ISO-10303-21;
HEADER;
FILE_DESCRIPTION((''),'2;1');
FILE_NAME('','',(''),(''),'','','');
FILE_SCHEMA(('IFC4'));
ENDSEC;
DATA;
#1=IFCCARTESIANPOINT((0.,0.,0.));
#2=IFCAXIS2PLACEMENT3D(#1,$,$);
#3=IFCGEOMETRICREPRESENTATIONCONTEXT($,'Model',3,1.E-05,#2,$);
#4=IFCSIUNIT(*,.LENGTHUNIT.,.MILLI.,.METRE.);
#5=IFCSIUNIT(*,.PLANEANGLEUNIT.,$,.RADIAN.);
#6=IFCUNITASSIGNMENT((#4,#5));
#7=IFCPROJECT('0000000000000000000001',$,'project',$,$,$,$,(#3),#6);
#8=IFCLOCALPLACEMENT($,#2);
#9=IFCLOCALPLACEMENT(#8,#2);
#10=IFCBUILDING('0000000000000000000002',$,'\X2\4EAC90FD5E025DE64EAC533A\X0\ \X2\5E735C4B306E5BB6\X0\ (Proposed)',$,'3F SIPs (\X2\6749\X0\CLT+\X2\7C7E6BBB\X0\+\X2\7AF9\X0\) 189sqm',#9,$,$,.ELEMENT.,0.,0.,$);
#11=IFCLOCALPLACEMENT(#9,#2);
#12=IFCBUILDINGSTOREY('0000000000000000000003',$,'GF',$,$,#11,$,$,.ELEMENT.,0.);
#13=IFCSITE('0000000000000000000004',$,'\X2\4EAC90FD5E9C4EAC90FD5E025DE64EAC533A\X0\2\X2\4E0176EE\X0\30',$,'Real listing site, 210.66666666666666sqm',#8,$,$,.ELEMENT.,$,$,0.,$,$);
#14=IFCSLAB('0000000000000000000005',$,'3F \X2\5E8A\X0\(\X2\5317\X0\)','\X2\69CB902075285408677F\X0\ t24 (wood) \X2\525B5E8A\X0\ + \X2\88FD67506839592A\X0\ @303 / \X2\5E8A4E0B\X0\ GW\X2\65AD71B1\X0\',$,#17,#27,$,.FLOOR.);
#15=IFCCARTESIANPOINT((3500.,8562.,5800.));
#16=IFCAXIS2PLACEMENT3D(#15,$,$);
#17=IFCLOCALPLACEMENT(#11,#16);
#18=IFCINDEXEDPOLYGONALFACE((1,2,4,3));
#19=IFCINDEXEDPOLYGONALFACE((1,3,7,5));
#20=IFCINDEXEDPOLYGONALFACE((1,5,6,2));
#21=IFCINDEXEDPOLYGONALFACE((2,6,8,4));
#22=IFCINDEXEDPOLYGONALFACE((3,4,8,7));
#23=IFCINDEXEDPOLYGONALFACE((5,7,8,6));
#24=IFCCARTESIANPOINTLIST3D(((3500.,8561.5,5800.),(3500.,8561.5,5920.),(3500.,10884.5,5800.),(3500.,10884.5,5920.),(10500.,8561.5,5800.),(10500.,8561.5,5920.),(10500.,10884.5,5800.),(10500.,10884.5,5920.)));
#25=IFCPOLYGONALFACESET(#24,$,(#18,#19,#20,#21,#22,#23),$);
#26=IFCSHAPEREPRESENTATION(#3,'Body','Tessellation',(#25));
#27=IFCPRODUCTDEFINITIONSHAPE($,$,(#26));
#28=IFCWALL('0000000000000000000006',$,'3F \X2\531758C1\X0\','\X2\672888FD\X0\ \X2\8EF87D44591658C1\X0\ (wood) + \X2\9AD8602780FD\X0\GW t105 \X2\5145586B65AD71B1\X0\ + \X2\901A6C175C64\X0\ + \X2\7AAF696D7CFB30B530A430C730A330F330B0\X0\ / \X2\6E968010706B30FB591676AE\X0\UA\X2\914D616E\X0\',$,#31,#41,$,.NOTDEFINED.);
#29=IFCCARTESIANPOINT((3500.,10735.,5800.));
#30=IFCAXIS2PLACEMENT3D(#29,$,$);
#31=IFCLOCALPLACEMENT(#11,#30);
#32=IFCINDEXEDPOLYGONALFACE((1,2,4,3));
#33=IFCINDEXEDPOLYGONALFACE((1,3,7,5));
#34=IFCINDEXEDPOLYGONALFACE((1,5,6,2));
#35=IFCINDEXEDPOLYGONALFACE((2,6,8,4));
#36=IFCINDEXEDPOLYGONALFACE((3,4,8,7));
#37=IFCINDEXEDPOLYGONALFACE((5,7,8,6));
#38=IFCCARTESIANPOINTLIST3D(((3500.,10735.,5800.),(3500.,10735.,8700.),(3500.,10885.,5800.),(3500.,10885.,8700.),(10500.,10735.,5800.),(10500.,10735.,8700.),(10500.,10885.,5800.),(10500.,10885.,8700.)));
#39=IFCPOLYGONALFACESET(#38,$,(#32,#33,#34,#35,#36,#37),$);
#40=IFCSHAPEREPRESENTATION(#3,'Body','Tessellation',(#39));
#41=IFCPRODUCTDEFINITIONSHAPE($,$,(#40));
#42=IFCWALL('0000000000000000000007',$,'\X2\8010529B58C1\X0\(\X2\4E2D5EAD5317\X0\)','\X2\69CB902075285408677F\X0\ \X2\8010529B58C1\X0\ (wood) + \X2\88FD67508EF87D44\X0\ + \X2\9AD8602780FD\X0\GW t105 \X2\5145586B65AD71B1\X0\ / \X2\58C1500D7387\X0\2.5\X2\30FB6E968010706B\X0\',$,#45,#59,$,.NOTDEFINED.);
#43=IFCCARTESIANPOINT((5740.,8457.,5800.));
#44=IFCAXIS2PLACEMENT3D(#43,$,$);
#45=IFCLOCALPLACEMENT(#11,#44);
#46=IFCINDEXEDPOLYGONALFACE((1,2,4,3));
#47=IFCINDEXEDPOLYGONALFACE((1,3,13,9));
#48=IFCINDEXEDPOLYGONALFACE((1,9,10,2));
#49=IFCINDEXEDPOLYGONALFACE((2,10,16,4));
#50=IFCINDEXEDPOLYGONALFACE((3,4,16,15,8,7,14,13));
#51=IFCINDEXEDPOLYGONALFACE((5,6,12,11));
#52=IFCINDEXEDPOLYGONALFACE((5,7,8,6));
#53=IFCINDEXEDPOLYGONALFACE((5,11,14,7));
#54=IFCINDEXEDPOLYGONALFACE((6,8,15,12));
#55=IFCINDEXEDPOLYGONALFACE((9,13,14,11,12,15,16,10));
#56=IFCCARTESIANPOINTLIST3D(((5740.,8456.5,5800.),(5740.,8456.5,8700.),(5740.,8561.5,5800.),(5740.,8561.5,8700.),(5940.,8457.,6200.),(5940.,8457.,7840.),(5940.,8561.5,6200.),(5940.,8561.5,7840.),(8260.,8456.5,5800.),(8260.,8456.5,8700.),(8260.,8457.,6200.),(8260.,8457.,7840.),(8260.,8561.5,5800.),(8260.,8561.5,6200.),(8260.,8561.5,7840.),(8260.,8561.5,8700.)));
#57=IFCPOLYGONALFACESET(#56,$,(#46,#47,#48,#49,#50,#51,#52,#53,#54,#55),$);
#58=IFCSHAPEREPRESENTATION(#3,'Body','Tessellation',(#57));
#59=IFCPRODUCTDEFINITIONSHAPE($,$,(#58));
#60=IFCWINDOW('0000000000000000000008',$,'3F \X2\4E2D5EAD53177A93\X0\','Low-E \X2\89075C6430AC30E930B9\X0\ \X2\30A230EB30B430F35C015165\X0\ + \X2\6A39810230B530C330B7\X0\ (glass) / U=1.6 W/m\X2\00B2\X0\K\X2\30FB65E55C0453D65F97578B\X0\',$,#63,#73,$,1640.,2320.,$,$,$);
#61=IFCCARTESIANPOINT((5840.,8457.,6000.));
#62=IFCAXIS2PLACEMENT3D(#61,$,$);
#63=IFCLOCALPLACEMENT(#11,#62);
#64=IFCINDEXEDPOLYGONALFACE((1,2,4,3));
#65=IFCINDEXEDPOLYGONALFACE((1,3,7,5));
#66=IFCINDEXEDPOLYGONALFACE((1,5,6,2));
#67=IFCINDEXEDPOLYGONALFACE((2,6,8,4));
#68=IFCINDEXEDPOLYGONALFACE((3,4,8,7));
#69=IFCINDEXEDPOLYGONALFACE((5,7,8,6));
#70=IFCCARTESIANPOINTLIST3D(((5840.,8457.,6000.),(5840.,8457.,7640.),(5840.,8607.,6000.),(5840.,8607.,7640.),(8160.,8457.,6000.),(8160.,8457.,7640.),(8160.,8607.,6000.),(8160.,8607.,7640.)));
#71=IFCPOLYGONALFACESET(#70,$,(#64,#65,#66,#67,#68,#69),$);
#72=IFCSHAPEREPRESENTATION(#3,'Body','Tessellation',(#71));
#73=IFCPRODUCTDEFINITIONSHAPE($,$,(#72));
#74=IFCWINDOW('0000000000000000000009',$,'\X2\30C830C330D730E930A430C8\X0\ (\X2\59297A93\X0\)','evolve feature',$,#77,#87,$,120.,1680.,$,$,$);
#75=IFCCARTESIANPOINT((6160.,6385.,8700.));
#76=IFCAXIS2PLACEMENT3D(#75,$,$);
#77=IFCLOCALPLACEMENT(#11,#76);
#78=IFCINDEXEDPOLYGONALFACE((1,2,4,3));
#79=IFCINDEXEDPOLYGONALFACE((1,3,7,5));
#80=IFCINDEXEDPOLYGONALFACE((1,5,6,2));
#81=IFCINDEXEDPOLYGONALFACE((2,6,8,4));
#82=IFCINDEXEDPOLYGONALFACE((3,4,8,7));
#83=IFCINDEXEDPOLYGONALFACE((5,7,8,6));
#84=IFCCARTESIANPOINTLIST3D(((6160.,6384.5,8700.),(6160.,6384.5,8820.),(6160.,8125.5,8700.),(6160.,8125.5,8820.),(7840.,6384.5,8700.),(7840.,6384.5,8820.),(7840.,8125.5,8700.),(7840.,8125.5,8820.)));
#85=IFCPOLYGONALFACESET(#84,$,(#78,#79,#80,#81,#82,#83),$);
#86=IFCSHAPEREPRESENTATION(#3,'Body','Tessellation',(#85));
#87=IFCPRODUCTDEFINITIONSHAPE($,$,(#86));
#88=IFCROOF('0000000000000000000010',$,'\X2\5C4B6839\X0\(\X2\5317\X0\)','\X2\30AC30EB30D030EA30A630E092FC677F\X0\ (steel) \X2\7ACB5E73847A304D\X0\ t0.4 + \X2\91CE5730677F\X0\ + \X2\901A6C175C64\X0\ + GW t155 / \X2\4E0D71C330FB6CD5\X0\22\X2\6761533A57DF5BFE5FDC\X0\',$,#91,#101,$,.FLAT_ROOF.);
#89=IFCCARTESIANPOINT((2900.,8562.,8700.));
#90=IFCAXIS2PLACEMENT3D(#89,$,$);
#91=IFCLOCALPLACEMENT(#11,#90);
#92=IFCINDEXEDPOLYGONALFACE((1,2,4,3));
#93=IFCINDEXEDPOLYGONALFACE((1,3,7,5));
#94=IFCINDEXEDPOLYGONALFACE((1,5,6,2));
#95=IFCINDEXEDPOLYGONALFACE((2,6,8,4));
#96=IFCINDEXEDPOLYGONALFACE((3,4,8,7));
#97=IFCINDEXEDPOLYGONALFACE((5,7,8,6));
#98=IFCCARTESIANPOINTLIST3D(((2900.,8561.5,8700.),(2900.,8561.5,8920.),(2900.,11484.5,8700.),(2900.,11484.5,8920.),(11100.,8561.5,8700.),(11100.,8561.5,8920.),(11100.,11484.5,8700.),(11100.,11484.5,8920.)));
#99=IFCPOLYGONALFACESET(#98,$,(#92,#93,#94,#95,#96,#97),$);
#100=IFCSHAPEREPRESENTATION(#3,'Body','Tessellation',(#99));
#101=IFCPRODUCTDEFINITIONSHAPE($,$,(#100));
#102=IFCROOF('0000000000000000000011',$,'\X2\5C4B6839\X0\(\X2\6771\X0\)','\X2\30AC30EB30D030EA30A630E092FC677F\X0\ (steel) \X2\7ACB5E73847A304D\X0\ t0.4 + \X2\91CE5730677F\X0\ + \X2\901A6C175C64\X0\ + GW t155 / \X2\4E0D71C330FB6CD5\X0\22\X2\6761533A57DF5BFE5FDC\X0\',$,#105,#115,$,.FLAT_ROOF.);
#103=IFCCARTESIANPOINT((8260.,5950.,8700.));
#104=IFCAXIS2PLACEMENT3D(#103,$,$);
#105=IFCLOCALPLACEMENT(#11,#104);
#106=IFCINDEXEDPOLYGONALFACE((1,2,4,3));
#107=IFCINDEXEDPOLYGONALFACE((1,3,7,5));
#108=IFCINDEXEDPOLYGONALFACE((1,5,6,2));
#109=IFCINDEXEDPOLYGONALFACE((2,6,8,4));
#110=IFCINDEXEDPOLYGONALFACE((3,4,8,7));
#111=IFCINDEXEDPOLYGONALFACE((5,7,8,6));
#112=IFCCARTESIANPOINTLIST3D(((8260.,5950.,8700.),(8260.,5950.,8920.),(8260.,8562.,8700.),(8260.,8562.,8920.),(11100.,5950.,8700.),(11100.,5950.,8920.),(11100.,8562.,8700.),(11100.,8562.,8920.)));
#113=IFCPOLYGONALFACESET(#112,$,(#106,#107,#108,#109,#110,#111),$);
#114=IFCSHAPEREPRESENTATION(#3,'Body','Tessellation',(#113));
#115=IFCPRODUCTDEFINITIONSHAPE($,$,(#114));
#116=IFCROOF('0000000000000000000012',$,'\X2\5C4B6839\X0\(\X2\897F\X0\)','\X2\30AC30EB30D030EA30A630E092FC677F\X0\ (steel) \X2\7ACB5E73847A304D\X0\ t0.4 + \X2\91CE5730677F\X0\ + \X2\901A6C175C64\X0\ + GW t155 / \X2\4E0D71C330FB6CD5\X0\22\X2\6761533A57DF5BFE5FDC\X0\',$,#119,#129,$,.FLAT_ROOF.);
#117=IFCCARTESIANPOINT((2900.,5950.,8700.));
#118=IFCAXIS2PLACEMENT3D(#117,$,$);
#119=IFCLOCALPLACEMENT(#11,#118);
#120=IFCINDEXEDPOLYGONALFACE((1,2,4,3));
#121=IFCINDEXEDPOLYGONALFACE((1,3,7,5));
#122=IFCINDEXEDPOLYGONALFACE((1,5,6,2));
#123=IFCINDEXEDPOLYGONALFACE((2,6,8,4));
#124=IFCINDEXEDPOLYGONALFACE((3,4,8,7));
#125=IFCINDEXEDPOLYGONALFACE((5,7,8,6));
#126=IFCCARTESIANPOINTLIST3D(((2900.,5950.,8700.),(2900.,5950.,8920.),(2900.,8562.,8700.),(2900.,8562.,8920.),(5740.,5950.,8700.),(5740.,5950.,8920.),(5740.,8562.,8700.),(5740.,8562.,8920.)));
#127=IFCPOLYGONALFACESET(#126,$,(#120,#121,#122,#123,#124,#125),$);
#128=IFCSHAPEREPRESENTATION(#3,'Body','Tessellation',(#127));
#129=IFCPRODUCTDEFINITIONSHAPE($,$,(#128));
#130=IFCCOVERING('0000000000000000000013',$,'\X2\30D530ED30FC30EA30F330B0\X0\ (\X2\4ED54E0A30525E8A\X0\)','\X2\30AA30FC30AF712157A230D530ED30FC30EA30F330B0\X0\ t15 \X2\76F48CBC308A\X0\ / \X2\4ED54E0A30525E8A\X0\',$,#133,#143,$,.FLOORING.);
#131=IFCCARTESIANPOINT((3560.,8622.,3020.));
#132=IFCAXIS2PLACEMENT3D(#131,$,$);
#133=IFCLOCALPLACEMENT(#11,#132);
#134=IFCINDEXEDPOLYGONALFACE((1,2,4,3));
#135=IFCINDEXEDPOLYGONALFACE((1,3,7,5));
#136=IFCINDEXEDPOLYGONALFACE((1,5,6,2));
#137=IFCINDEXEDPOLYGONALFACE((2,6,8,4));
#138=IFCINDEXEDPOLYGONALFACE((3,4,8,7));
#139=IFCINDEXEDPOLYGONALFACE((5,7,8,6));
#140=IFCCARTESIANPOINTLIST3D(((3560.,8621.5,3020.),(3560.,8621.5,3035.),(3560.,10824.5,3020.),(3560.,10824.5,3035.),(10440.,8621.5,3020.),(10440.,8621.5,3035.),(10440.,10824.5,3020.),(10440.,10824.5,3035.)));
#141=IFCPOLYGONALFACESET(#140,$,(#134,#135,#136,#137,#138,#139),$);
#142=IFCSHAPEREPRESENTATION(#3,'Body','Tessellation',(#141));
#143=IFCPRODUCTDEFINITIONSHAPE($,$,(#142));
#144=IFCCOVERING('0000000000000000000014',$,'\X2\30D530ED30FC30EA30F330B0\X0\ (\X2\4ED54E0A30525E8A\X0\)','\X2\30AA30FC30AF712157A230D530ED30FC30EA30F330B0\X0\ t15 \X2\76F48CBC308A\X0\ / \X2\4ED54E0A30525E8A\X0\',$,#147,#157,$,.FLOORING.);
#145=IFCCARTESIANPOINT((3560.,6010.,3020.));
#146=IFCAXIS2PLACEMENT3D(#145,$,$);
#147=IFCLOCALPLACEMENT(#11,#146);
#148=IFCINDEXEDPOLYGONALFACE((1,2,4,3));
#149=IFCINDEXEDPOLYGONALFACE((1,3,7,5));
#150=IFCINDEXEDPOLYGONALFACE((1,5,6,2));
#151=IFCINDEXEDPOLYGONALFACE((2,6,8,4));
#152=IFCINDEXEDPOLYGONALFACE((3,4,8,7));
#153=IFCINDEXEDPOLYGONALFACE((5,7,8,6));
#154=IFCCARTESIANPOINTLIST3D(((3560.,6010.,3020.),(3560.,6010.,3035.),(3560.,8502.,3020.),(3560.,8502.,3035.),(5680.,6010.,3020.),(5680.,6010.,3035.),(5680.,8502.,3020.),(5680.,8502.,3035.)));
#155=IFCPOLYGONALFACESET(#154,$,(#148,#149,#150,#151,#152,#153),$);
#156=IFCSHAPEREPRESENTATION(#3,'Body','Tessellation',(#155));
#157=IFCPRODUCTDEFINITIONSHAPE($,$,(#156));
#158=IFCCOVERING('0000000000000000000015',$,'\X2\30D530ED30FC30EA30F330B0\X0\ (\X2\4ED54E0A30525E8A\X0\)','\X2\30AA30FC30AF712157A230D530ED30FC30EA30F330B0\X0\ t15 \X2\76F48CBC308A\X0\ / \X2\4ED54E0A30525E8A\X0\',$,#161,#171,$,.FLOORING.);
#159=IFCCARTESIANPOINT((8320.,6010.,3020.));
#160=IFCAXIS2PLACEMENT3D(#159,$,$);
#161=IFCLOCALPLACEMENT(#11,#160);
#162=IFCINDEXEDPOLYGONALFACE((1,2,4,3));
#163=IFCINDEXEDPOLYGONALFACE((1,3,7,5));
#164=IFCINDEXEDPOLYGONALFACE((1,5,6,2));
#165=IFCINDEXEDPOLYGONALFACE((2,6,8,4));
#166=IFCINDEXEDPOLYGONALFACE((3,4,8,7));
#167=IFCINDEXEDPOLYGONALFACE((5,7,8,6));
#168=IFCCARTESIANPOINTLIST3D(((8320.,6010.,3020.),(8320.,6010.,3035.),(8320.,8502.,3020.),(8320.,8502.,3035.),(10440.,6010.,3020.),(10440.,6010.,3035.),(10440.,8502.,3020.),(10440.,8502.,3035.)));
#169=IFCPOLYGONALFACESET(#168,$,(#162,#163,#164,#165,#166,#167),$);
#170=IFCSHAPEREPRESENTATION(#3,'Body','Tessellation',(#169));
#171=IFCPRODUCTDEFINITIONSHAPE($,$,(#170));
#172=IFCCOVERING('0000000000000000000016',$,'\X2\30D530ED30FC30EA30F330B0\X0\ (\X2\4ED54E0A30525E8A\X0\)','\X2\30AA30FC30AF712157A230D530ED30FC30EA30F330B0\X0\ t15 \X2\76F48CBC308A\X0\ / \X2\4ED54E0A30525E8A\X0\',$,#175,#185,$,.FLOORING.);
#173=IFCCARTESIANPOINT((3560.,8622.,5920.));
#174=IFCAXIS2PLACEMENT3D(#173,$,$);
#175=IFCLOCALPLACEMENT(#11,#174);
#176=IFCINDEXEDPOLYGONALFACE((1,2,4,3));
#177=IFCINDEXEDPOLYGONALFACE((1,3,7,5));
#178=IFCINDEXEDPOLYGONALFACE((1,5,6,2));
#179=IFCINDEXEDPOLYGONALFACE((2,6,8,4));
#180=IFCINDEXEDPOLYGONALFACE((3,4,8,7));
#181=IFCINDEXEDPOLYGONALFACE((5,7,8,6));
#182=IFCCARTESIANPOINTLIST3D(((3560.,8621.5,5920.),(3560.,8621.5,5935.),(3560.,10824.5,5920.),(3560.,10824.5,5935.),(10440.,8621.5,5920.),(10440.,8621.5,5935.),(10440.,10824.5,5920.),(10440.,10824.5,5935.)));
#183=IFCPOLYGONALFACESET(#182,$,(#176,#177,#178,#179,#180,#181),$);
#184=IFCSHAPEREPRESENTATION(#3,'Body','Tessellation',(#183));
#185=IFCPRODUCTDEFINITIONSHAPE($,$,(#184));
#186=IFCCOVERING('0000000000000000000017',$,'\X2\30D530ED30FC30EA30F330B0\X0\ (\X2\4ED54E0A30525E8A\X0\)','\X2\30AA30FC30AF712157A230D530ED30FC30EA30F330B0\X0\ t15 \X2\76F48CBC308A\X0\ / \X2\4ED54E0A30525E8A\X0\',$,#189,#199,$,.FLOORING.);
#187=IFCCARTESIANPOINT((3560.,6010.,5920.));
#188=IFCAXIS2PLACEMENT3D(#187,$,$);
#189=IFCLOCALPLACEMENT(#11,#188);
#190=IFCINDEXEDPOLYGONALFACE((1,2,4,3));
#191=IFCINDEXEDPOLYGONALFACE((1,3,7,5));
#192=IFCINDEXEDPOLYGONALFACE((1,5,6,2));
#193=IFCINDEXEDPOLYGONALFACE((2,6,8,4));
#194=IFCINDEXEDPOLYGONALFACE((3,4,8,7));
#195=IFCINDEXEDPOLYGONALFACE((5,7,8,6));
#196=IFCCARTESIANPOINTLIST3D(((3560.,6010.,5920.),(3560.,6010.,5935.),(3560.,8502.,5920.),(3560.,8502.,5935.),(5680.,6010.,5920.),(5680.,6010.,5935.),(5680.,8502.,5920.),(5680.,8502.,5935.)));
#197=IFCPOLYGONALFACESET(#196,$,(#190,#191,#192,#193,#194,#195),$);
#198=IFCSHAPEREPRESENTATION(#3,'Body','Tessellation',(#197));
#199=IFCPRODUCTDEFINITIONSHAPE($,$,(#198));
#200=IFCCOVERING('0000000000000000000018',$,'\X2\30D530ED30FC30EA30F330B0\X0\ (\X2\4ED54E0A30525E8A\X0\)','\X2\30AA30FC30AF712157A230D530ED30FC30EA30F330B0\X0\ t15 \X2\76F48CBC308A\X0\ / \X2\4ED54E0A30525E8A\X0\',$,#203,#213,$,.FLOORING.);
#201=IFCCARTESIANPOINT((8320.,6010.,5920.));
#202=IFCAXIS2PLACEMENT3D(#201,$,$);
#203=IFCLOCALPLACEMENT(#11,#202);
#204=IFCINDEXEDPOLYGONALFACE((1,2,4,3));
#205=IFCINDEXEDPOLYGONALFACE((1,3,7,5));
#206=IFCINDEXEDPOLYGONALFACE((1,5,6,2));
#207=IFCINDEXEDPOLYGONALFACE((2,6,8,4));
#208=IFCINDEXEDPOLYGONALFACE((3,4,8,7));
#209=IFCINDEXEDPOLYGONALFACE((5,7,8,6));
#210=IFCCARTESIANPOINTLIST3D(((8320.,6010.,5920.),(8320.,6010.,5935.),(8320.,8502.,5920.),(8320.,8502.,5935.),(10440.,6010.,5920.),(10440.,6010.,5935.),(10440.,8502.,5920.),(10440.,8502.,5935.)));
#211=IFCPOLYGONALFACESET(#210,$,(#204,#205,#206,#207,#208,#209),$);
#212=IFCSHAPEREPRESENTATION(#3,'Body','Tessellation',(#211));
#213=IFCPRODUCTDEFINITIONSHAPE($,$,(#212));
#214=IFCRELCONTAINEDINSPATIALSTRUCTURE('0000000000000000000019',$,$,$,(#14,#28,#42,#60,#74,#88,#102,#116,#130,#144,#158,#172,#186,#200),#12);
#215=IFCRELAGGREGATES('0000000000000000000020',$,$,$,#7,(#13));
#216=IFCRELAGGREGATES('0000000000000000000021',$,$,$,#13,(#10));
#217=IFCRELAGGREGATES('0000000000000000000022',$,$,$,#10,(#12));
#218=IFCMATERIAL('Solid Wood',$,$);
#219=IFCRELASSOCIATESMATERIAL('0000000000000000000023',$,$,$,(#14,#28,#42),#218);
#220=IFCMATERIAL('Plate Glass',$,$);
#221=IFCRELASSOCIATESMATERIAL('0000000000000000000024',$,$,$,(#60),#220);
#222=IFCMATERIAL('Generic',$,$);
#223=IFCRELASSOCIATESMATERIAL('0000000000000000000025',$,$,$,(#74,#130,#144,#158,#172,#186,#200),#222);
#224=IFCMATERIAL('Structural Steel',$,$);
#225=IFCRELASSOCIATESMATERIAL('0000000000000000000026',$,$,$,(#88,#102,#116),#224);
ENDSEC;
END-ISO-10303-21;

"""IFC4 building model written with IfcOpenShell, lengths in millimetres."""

from ifc_helpers import new_model, si_unit, frame, frame_2d, origin, place, context, project, spatial, rectangle, extrude, material, element, fill, save


model = new_model("IFC4")

# Units and contexts
model_context = context("Model", 3, precision=1e-05, world=origin())
ifc_project = project(units=[si_unit("LENGTHUNIT", "METRE", prefix="MILLI"), si_unit("PLANEANGLEUNIT", "RADIAN")], contexts=[model_context])

# Site, building, storey
site_placement = place(None, origin())
site = spatial("IfcSite", under=ifc_project, at=site_placement, Name="京都府京都市左京区2丁目30", ObjectType="Real listing site, 210.66666666666666sqm", CompositionType="ELEMENT", RefElevation=0.0)
building_placement = place(site_placement, origin())
building = spatial("IfcBuilding", under=site, at=building_placement, Name="京都市左京区 平屋の家 (Proposed)", ObjectType="3F SIPs (杉CLT+籾殻+竹) 189sqm", CompositionType="ELEMENT", ElevationOfRefHeight=0.0, ElevationOfTerrain=0.0)
storey_placement = place(building_placement, origin())
storey = spatial("IfcBuildingStorey", under=building, at=storey_placement, Name="GF", CompositionType="ELEMENT", Elevation=0.0)

# Slab
ifc_material_1 = material(Name="Solid Wood")
slab_placement = place(storey_placement, frame((3500.0, 8562.0, 5800.0)))
element("IfcSlab", 1, at=slab_placement, inside=storey, material=ifc_material_1, Name="3F 床(北)", Description="構造用合板 t24 (wood) 剛床 + 製材根太 @303 / 床下 GW断熱", PredefinedType="FLOOR", context=model_context, shape_type="SweptSolid", body=[
    extrude(rectangle(XDim=7000.0, YDim=2323.0, at=frame_2d((3500.0, 1161.0))), frame((3500.0, 8562.0, 5800.0)), (0.0, 0.0, 1.0), 120.0),
])

# Wall
wall_1_placement = place(storey_placement, frame((3500.0, 10735.0, 5800.0)))
element("IfcWall", 2, at=wall_1_placement, inside=storey, material=ifc_material_1, Name="3F 北壁", Description="木製 軸組外壁 (wood) + 高性能GW t105 充填断熱 + 通気層 + 窯業系サイディング / 準耐火・外皮UA配慮", PredefinedType="NOTDEFINED", context=model_context, shape_type="SweptSolid", body=[
    extrude(rectangle(XDim=7000.0, YDim=150.0, at=frame_2d((3500.0, 75.0))), frame((3500.0, 10735.0, 5800.0)), (0.0, 0.0, 1.0), 2900.0),
])

# Wall, opening, window
wall_2_placement = place(storey_placement, frame((5740.0, 8457.0, 5800.0)))
wall_2 = element("IfcWall", 3, at=wall_2_placement, inside=storey, material=ifc_material_1, Name="耐力壁(中庭北)", Description="構造用合板 耐力壁 (wood) + 製材軸組 + 高性能GW t105 充填断熱 / 壁倍率2.5・準耐火", PredefinedType="NOTDEFINED", context=model_context, shape_type="SweptSolid", body=[
    extrude(rectangle(XDim=2520.0, YDim=105.0, at=frame_2d((1260.0, 52.0))), frame((5740.0, 8457.0, 5800.0)), (0.0, 0.0, 1.0), 2900.0),
])
opening_placement = place(storey_placement, frame((5840.0, 8457.0, 6000.0)))
opening = element("IfcOpeningElement", 4, at=opening_placement, cuts=wall_2, PredefinedType="NOTDEFINED", context=model_context, shape_type="SweptSolid", body=[
    extrude(rectangle(XDim=2320.0, YDim=150.0, at=frame_2d((1160.0, 75.0))), frame((5840.0, 8457.0, 6000.0)), (0.0, 0.0, 1.0), 1640.0),
])
ifc_material_2 = material(Name="Plate Glass")
window_1_placement = place(storey_placement, frame((5840.0, 8457.0, 6000.0)))
window_1 = element("IfcWindow", 5, at=window_1_placement, inside=storey, material=ifc_material_2, Name="3F 中庭北窓", Description="Low-E 複層ガラス アルゴン封入 + 樹脂サッシ (glass) / U=1.6 W/m²K・日射取得型", OverallHeight=1640.0, OverallWidth=2320.0, context=model_context, shape_type="SweptSolid", body=[
    extrude(rectangle(XDim=2320.0, YDim=150.0, at=frame_2d((1160.0, 75.0))), frame((5840.0, 8457.0, 6000.0)), (0.0, 0.0, 1.0), 1640.0),
])
fill(opening, window_1)

# Window
ifc_material_3 = material(Name="Generic")
window_2_placement = place(storey_placement, frame((6160.0, 6385.0, 8700.0)))
element("IfcWindow", 6, at=window_2_placement, inside=storey, material=ifc_material_3, Name="トップライト (天窓)", Description="evolve feature", OverallHeight=120.0, OverallWidth=1680.0, context=model_context, shape_type="SweptSolid", body=[
    extrude(rectangle(XDim=1680.0, YDim=1741.0, at=frame_2d((840.0, 870.0))), frame((6160.0, 6385.0, 8700.0)), (0.0, 0.0, 1.0), 120.0),
])

# Roofs
ifc_material_4 = material(Name="Structural Steel")
roof_1_placement = place(storey_placement, frame((2900.0, 8562.0, 8700.0)))
element("IfcRoof", 7, at=roof_1_placement, inside=storey, material=ifc_material_4, Name="屋根(北)", Description="ガルバリウム鋼板 (steel) 立平葺き t0.4 + 野地板 + 通気層 + GW t155 / 不燃・法22条区域対応", PredefinedType="FLAT_ROOF", context=model_context, shape_type="SweptSolid", body=[
    extrude(rectangle(XDim=8200.0, YDim=2923.0, at=frame_2d((4100.0, 1461.0))), frame((2900.0, 8562.0, 8700.0)), (0.0, 0.0, 1.0), 220.0),
])
roof_2_placement = place(storey_placement, frame((8260.0, 5950.0, 8700.0)))
element("IfcRoof", 8, at=roof_2_placement, inside=storey, material=ifc_material_4, Name="屋根(東)", Description="ガルバリウム鋼板 (steel) 立平葺き t0.4 + 野地板 + 通気層 + GW t155 / 不燃・法22条区域対応", PredefinedType="FLAT_ROOF", context=model_context, shape_type="SweptSolid", body=[
    extrude(rectangle(XDim=2840.0, YDim=2612.0, at=frame_2d((1420.0, 1306.0))), frame((8260.0, 5950.0, 8700.0)), (0.0, 0.0, 1.0), 220.0),
])
roof_3_placement = place(storey_placement, frame((2900.0, 5950.0, 8700.0)))
element("IfcRoof", 9, at=roof_3_placement, inside=storey, material=ifc_material_4, Name="屋根(西)", Description="ガルバリウム鋼板 (steel) 立平葺き t0.4 + 野地板 + 通気層 + GW t155 / 不燃・法22条区域対応", PredefinedType="FLAT_ROOF", context=model_context, shape_type="SweptSolid", body=[
    extrude(rectangle(XDim=2840.0, YDim=2612.0, at=frame_2d((1420.0, 1306.0))), frame((2900.0, 5950.0, 8700.0)), (0.0, 0.0, 1.0), 220.0),
])

# Coverings
covering_1_placement = place(storey_placement, frame((3560.0, 8622.0, 3020.0)))
element("IfcCovering", 10, at=covering_1_placement, inside=storey, material=ifc_material_3, Name="フローリング (仕上げ床)", Description="オーク無垢フローリング t15 直貼り / 仕上げ床", PredefinedType="FLOORING", context=model_context, shape_type="SweptSolid", body=[
    extrude(rectangle(XDim=6880.0, YDim=2203.0, at=frame_2d((3440.0, 1101.0))), frame((3560.0, 8622.0, 3020.0)), (0.0, 0.0, 1.0), 15.0),
])
covering_2_placement = place(storey_placement, frame((3560.0, 6010.0, 3020.0)))
element("IfcCovering", 11, at=covering_2_placement, inside=storey, material=ifc_material_3, Name="フローリング (仕上げ床)", Description="オーク無垢フローリング t15 直貼り / 仕上げ床", PredefinedType="FLOORING", context=model_context, shape_type="SweptSolid", body=[
    extrude(rectangle(XDim=2120.0, YDim=2492.0, at=frame_2d((1060.0, 1246.0))), frame((3560.0, 6010.0, 3020.0)), (0.0, 0.0, 1.0), 15.0),
])
covering_3_placement = place(storey_placement, frame((8320.0, 6010.0, 3020.0)))
element("IfcCovering", 12, at=covering_3_placement, inside=storey, material=ifc_material_3, Name="フローリング (仕上げ床)", Description="オーク無垢フローリング t15 直貼り / 仕上げ床", PredefinedType="FLOORING", context=model_context, shape_type="SweptSolid", body=[
    extrude(rectangle(XDim=2120.0, YDim=2492.0, at=frame_2d((1060.0, 1246.0))), frame((8320.0, 6010.0, 3020.0)), (0.0, 0.0, 1.0), 15.0),
])
covering_4_placement = place(storey_placement, frame((3560.0, 8622.0, 5920.0)))
element("IfcCovering", 13, at=covering_4_placement, inside=storey, material=ifc_material_3, Name="フローリング (仕上げ床)", Description="オーク無垢フローリング t15 直貼り / 仕上げ床", PredefinedType="FLOORING", context=model_context, shape_type="SweptSolid", body=[
    extrude(rectangle(XDim=6880.0, YDim=2203.0, at=frame_2d((3440.0, 1101.0))), frame((3560.0, 8622.0, 5920.0)), (0.0, 0.0, 1.0), 15.0),
])
covering_5_placement = place(storey_placement, frame((3560.0, 6010.0, 5920.0)))
element("IfcCovering", 14, at=covering_5_placement, inside=storey, material=ifc_material_3, Name="フローリング (仕上げ床)", Description="オーク無垢フローリング t15 直貼り / 仕上げ床", PredefinedType="FLOORING", context=model_context, shape_type="SweptSolid", body=[
    extrude(rectangle(XDim=2120.0, YDim=2492.0, at=frame_2d((1060.0, 1246.0))), frame((3560.0, 6010.0, 5920.0)), (0.0, 0.0, 1.0), 15.0),
])
covering_6_placement = place(storey_placement, frame((8320.0, 6010.0, 5920.0)))
element("IfcCovering", 15, at=covering_6_placement, inside=storey, material=ifc_material_3, Name="フローリング (仕上げ床)", Description="オーク無垢フローリング t15 直貼り / 仕上げ床", PredefinedType="FLOORING", context=model_context, shape_type="SweptSolid", body=[
    extrude(rectangle(XDim=2120.0, YDim=2492.0, at=frame_2d((1060.0, 1246.0))), frame((8320.0, 6010.0, 5920.0)), (0.0, 0.0, 1.0), 15.0),
])

save(model, "model.ifc")
